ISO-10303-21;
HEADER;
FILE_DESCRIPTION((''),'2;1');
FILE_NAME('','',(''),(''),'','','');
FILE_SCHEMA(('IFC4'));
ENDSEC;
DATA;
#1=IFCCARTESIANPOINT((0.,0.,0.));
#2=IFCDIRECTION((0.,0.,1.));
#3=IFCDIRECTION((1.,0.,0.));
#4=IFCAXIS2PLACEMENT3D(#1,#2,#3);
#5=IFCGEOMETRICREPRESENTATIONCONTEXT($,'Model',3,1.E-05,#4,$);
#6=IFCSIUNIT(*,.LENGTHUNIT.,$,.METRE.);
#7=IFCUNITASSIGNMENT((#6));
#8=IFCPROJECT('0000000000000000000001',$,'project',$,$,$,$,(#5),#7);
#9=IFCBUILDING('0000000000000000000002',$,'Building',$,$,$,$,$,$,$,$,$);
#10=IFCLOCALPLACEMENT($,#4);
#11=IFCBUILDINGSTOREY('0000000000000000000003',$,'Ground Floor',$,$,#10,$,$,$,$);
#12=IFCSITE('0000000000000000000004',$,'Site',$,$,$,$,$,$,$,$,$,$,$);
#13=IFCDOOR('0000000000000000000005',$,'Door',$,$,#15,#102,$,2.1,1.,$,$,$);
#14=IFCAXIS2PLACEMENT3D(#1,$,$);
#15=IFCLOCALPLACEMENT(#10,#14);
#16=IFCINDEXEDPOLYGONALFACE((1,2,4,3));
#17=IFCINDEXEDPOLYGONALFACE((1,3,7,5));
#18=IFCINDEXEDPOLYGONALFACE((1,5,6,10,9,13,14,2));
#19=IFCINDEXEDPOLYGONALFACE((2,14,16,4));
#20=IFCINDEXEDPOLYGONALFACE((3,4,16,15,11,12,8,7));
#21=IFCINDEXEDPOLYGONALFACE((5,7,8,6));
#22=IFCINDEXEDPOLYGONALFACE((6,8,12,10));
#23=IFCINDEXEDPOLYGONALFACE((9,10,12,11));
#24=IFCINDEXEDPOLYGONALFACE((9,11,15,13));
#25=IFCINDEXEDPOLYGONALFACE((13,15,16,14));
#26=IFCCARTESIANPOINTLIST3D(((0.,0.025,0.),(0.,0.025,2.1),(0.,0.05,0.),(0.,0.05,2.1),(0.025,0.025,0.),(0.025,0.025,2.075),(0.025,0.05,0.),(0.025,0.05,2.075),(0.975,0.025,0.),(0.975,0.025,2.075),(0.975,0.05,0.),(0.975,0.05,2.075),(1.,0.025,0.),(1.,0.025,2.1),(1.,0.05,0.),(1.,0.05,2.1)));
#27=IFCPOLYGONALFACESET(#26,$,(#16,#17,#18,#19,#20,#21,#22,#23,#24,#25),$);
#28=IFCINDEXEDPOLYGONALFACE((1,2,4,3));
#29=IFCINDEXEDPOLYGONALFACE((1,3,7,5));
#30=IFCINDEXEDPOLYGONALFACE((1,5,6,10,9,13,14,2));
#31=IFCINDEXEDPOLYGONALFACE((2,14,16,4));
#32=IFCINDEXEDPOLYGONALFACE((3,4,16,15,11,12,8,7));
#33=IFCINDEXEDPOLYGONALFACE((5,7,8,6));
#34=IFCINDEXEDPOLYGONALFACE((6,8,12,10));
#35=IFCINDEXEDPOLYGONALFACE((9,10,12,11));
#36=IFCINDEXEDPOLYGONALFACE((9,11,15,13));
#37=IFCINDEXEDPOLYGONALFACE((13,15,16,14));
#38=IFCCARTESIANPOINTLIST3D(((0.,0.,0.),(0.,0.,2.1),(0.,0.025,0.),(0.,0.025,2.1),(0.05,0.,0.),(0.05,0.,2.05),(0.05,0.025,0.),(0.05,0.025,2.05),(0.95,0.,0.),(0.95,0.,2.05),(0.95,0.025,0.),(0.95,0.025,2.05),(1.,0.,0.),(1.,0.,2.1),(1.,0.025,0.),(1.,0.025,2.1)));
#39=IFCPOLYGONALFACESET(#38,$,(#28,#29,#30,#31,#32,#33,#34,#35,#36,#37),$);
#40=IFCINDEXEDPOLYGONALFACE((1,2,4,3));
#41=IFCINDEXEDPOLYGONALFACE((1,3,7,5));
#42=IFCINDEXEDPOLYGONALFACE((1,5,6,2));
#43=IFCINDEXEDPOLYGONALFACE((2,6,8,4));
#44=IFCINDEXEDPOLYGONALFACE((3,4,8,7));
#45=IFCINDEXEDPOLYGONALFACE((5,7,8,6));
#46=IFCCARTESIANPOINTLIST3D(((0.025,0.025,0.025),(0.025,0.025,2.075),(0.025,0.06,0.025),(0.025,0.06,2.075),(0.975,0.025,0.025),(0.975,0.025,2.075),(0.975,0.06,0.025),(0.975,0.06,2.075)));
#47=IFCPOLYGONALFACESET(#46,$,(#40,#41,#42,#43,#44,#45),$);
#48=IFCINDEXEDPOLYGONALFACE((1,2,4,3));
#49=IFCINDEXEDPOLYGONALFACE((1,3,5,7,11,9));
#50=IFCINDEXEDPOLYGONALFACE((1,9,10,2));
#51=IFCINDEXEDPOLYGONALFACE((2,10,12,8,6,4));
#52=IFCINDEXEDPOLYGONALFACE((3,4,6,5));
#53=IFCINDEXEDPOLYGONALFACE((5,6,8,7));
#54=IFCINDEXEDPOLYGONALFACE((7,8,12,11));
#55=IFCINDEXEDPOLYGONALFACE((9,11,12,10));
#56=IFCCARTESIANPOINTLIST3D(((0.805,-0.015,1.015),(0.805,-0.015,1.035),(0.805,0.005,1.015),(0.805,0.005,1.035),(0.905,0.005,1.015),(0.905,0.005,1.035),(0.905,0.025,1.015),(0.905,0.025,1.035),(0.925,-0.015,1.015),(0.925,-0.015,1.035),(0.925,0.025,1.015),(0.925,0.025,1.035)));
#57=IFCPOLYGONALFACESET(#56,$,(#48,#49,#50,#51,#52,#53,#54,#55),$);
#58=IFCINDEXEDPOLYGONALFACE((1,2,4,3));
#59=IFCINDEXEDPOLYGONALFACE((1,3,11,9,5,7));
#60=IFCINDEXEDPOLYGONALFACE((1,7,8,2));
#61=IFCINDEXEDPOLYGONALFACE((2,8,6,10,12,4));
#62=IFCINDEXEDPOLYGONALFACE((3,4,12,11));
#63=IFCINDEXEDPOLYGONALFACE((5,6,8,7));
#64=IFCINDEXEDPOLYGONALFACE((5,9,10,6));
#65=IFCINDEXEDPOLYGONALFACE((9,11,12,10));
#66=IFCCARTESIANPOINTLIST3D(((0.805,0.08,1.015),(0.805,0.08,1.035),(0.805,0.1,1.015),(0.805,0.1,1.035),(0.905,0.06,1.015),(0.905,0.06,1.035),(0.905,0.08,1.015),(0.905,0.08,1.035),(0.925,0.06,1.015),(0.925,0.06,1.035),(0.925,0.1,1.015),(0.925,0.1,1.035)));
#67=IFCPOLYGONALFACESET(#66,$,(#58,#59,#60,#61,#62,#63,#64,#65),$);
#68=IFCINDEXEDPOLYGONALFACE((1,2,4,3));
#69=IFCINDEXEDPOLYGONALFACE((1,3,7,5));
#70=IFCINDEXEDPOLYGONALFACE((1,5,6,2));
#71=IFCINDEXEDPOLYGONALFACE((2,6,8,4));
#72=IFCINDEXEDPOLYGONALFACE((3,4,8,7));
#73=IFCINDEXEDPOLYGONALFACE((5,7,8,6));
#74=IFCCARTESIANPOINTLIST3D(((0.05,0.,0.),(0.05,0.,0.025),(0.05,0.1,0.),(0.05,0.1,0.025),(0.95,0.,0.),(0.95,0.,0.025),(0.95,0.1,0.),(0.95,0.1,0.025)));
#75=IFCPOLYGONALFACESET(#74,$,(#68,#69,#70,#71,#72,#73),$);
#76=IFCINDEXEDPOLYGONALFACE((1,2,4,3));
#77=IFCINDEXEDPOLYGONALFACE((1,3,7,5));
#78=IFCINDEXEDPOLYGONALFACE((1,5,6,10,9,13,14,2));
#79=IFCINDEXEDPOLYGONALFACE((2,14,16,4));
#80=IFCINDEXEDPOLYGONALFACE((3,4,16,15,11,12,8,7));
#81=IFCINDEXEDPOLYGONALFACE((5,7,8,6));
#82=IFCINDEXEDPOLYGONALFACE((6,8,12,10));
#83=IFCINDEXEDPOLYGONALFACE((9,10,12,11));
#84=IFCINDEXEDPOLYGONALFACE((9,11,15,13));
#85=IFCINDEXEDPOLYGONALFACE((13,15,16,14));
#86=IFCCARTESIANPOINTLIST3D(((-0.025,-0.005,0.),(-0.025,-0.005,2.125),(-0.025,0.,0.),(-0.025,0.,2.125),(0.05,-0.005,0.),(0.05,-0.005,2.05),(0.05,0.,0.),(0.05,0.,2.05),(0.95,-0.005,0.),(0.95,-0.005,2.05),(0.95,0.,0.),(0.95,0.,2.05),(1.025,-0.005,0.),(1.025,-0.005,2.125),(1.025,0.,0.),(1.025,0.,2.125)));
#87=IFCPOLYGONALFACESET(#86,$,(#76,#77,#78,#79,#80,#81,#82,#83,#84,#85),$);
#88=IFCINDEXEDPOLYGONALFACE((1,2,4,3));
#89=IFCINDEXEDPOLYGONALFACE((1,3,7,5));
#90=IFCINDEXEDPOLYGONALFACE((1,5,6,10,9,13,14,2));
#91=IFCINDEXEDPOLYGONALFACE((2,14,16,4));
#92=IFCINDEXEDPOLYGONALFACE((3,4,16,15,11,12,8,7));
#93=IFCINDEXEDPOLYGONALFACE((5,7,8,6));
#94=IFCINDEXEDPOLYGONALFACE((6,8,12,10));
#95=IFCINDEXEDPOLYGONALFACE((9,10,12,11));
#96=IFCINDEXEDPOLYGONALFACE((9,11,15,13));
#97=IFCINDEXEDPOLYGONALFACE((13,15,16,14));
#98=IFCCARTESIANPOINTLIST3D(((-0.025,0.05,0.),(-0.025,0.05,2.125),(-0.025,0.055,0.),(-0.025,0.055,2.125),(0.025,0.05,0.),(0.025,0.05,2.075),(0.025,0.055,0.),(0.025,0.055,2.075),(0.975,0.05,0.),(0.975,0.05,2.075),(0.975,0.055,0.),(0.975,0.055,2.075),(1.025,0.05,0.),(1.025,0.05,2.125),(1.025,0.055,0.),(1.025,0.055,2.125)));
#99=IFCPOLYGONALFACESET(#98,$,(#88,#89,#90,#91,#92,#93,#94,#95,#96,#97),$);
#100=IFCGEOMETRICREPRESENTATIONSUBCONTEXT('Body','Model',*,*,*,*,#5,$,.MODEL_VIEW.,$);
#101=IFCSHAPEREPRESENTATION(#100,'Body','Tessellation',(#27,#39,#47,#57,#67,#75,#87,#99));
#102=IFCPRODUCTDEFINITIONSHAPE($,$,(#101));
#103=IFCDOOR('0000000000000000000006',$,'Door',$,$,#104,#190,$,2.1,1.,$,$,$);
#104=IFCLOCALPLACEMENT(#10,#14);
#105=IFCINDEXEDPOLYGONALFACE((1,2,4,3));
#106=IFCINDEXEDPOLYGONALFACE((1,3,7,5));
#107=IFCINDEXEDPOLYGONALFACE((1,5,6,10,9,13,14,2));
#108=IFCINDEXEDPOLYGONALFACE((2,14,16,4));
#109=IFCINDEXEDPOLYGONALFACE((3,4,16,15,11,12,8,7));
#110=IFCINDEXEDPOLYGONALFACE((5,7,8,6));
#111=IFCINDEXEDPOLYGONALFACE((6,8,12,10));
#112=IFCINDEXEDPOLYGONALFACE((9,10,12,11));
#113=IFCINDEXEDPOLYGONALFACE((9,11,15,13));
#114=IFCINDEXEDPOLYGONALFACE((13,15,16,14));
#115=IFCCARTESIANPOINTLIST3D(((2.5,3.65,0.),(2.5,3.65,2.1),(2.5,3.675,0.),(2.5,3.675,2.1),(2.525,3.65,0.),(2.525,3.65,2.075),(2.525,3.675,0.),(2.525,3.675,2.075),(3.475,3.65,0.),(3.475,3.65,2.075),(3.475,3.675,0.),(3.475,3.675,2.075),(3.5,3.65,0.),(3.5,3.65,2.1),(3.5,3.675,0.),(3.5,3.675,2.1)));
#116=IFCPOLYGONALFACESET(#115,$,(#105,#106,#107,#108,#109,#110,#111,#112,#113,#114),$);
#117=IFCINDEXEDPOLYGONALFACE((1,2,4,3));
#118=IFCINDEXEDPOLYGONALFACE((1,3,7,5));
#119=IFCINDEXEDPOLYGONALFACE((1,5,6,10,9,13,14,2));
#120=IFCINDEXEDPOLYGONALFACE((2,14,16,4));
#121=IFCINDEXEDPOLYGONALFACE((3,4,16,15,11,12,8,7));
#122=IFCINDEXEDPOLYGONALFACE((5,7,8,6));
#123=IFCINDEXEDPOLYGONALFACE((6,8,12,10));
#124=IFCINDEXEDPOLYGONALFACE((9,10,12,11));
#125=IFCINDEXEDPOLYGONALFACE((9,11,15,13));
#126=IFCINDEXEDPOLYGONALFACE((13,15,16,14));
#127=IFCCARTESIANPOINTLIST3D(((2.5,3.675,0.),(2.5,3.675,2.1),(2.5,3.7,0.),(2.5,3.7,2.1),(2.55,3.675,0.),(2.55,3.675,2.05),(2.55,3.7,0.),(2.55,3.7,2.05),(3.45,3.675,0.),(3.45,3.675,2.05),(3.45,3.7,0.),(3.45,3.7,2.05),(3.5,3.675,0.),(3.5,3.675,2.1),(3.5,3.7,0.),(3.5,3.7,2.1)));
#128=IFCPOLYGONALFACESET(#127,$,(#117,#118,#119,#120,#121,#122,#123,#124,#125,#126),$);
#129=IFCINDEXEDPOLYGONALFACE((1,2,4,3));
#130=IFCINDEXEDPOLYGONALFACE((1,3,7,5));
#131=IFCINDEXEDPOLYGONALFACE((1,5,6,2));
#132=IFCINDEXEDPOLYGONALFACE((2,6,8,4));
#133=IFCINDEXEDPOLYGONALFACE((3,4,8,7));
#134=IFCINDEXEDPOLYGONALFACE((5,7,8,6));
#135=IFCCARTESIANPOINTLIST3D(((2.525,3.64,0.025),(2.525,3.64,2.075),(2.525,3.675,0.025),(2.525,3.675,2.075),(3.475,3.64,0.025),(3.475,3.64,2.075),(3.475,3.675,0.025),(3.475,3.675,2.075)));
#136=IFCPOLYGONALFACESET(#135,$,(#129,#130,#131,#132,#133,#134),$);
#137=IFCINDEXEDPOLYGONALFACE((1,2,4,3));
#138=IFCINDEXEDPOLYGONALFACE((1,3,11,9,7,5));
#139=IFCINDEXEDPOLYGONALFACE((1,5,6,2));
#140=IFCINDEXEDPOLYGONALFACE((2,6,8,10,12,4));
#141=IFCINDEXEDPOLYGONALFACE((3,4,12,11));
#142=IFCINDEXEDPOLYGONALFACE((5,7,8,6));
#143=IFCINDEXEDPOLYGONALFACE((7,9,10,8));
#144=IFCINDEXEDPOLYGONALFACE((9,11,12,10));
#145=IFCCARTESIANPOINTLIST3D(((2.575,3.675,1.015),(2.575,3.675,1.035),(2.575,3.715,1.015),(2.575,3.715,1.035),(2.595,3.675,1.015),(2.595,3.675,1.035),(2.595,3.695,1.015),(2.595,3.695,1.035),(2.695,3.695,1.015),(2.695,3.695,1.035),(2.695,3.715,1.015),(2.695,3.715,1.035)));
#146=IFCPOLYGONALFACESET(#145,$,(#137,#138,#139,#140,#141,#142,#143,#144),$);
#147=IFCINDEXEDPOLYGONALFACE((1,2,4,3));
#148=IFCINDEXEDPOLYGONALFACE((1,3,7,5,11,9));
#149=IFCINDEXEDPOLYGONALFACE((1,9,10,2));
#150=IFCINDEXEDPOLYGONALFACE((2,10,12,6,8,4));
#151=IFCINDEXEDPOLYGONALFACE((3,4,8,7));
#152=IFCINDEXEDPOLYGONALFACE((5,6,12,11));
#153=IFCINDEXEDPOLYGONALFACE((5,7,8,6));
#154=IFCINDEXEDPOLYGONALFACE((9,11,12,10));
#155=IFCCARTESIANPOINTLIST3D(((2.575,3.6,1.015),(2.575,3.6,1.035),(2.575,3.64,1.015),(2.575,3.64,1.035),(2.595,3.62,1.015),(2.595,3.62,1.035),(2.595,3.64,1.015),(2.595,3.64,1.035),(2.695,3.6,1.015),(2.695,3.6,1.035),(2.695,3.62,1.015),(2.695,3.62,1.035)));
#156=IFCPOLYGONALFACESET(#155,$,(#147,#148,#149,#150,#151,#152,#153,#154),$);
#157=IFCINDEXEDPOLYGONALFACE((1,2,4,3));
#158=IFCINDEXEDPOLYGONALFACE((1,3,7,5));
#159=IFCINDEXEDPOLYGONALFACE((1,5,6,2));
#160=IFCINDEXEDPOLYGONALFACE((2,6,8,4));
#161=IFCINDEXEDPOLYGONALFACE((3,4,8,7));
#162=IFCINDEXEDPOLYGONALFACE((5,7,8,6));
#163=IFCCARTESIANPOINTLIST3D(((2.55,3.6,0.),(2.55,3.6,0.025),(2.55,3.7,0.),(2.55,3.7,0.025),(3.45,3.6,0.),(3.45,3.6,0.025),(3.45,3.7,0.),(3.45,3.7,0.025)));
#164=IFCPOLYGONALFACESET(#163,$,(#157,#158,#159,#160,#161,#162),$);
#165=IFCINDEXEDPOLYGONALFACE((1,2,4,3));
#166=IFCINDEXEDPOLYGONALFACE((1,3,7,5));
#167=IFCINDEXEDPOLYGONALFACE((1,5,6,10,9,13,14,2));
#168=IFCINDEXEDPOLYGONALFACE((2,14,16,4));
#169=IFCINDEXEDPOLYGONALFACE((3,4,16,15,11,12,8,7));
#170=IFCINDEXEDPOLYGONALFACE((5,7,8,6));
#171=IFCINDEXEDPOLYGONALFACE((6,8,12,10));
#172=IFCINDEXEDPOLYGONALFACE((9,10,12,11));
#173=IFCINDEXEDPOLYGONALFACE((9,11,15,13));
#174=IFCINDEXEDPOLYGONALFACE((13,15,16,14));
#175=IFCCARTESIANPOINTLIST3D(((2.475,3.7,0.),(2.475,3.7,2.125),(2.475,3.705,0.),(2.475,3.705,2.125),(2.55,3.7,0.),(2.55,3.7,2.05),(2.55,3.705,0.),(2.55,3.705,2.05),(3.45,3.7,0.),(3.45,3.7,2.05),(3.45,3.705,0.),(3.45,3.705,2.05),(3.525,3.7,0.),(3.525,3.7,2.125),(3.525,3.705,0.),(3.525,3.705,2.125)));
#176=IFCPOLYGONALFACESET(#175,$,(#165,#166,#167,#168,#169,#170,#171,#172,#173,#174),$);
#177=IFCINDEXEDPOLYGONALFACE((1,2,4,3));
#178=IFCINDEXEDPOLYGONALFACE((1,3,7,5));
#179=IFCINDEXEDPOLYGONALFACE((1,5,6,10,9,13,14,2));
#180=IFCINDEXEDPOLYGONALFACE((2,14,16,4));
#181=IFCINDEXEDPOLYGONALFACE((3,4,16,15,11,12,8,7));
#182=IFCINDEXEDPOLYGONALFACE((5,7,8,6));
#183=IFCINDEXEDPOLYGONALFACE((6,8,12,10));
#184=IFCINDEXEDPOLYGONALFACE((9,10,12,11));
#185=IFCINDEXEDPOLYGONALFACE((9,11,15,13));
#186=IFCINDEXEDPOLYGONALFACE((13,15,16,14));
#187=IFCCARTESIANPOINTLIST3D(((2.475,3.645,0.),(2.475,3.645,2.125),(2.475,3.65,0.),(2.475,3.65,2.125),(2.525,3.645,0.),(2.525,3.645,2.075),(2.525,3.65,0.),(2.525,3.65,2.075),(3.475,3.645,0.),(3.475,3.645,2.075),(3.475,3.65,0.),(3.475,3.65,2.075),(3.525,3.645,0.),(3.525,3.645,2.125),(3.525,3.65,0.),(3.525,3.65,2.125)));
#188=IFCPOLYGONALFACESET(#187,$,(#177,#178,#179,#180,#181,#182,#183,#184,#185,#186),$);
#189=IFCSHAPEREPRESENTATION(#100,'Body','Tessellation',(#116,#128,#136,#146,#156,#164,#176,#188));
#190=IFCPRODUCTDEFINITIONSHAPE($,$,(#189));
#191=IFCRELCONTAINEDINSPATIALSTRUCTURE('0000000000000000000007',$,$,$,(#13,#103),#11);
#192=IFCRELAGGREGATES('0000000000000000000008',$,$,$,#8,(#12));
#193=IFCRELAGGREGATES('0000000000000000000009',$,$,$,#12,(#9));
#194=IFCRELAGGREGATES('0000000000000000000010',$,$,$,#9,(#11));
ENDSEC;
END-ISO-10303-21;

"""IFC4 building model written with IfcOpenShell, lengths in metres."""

from ifc_helpers import new_model, si_unit, frame, origin_with_axes, place, context, subcontext, project, spatial, line, indexed_curve, outline, extrude, element, save


model = new_model("IFC4")

# Units and contexts
model_context = context("Model", 3, precision=1e-05, world=origin_with_axes())
body_context = subcontext(model_context, "Body", "Model", "MODEL_VIEW")
ifc_project = project(units=[si_unit("LENGTHUNIT", "METRE")], contexts=[model_context])

# Site, building, storey
site = spatial("IfcSite", under=ifc_project, Name="Site")
building = spatial("IfcBuilding", under=site, Name="Building")
storey_placement = place(None, origin_with_axes())
storey = spatial("IfcBuildingStorey", under=building, at=storey_placement, Name="Ground Floor")

# Doors
door_1_placement = place(storey_placement, origin_with_axes())
element("IfcDoor", 1, at=door_1_placement, inside=storey, Name="Door", OverallHeight=2.1, OverallWidth=1.0, context=body_context, shape_type="SweptSolid", body=[
    extrude(outline(indexed_curve([(0.0, 0.0), (0.0, 2.1), (1.0, 2.1), (1.0, 0.0), (0.975, 0.0), (0.975, 2.075), (0.025, 2.075), (0.025, 0.0)], segments=[line(1, 2, 3, 4, 5, 6, 7, 8, 1)])), frame((0.0, 0.025, 0.0), z_axis=(0.0, -1.0, 0.0), x_axis=(1.0, 0.0, 0.0)), (0.0, 0.0, -1.0), 0.025),
    extrude(outline(indexed_curve([(0.0, 0.0), (0.0, 2.1), (1.0, 2.1), (1.0, 0.0), (0.95, 0.0), (0.95, 2.05), (0.05, 2.05), (0.05, 0.0)], segments=[line(1, 2, 3, 4, 5, 6, 7, 8, 1)])), frame((0.0, 0.0, 0.0), z_axis=(0.0, -1.0, 0.0), x_axis=(1.0, 0.0, 0.0)), (0.0, 0.0, -1.0), 0.025),
    extrude(outline(indexed_curve([(0.0, 0.0), (0.95, 0.0), (0.95, 0.035), (0.0, 0.035)], segments=[line(1, 2, 3, 4, 1)])), frame((0.025, 0.025, 0.025), z_axis=(0.0, 0.0, 1.0), x_axis=(1.0, 0.0, 0.0)), (0.0, 0.0, 1.0), 2.05),
    extrude(outline(indexed_curve([(0.0, 0.0), (0.0, -0.04), (-0.12, -0.04), (-0.12, -0.02), (-0.02, -0.02), (-0.02, 0.0)], segments=[line(1, 2, 3, 4, 5, 6, 1)])), frame((0.925, 0.025, 1.015), z_axis=(0.0, 0.0, 1.0), x_axis=(1.0, 0.0, 0.0)), (0.0, 0.0, 1.0), 0.02),
    extrude(outline(indexed_curve([(0.0, 0.0), (0.0, 0.04), (-0.12, 0.04), (-0.12, 0.02), (-0.02, 0.02), (-0.02, 0.0)], segments=[line(1, 2, 3, 4, 5, 6, 1)])), frame((0.925, 0.06, 1.015), z_axis=(0.0, 0.0, 1.0), x_axis=(1.0, 0.0, 0.0)), (0.0, 0.0, 1.0), 0.02),
    extrude(outline(indexed_curve([(0.0, 0.0), (0.9, 0.0), (0.9, 0.1), (0.0, 0.1)], segments=[line(1, 2, 3, 4, 1)])), frame((0.05, 0.0, 0.0), z_axis=(0.0, 0.0, 1.0), x_axis=(1.0, 0.0, 0.0)), (0.0, 0.0, 1.0), 0.025),
    extrude(outline(indexed_curve([(0.0, 0.0), (0.0, 2.125), (1.05, 2.125), (1.05, 0.0), (0.975, 0.0), (0.975, 2.05), (0.075, 2.05), (0.075, 0.0)], segments=[line(1, 2, 3, 4, 5, 6, 7, 8, 1)])), frame((-0.025, -0.005, 0.0), z_axis=(0.0, -1.0, 0.0), x_axis=(1.0, 0.0, 0.0)), (0.0, 0.0, -1.0), 0.005),
    extrude(outline(indexed_curve([(0.0, 0.0), (0.0, 2.125), (1.05, 2.125), (1.05, 0.0), (1.0, 0.0), (1.0, 2.075), (0.05, 2.075), (0.05, 0.0)], segments=[line(1, 2, 3, 4, 5, 6, 7, 8, 1)])), frame((-0.025, 0.05, 0.0), z_axis=(0.0, -1.0, 0.0), x_axis=(1.0, 0.0, 0.0)), (0.0, 0.0, -1.0), 0.005),
])
door_2_placement = place(storey_placement, frame((3.5, 3.7, 0.0), z_axis=(0.0, 0.0, 1.0), x_axis=(-1.0, 0.0, 0.0)))
element("IfcDoor", 2, at=door_2_placement, inside=storey, Name="Door", OverallHeight=2.1, OverallWidth=1.0, context=body_context, shape_type="SweptSolid", body=[
    extrude(outline(indexed_curve([(0.0, 0.0), (0.0, 2.1), (1.0, 2.1), (1.0, 0.0), (0.975, 0.0), (0.975, 2.075), (0.025, 2.075), (0.025, 0.0)], segments=[line(1, 2, 3, 4, 5, 6, 7, 8, 1)])), frame((0.0, 0.025, 0.0), z_axis=(0.0, -1.0, 0.0), x_axis=(1.0, 0.0, 0.0)), (0.0, 0.0, -1.0), 0.025),
    extrude(outline(indexed_curve([(0.0, 0.0), (0.0, 2.1), (1.0, 2.1), (1.0, 0.0), (0.95, 0.0), (0.95, 2.05), (0.05, 2.05), (0.05, 0.0)], segments=[line(1, 2, 3, 4, 5, 6, 7, 8, 1)])), frame((0.0, 0.0, 0.0), z_axis=(0.0, -1.0, 0.0), x_axis=(1.0, 0.0, 0.0)), (0.0, 0.0, -1.0), 0.025),
    extrude(outline(indexed_curve([(0.0, 0.0), (0.95, 0.0), (0.95, 0.035), (0.0, 0.035)], segments=[line(1, 2, 3, 4, 1)])), frame((0.025, 0.025, 0.025), z_axis=(0.0, 0.0, 1.0), x_axis=(1.0, 0.0, 0.0)), (0.0, 0.0, 1.0), 2.05),
    extrude(outline(indexed_curve([(0.0, 0.0), (0.0, -0.04), (-0.12, -0.04), (-0.12, -0.02), (-0.02, -0.02), (-0.02, 0.0)], segments=[line(1, 2, 3, 4, 5, 6, 1)])), frame((0.925, 0.025, 1.015), z_axis=(0.0, 0.0, 1.0), x_axis=(1.0, 0.0, 0.0)), (0.0, 0.0, 1.0), 0.02),
    extrude(outline(indexed_curve([(0.0, 0.0), (0.0, 0.04), (-0.12, 0.04), (-0.12, 0.02), (-0.02, 0.02), (-0.02, 0.0)], segments=[line(1, 2, 3, 4, 5, 6, 1)])), frame((0.925, 0.06, 1.015), z_axis=(0.0, 0.0, 1.0), x_axis=(1.0, 0.0, 0.0)), (0.0, 0.0, 1.0), 0.02),
    extrude(outline(indexed_curve([(0.0, 0.0), (0.9, 0.0), (0.9, 0.1), (0.0, 0.1)], segments=[line(1, 2, 3, 4, 1)])), frame((0.05, 0.0, 0.0), z_axis=(0.0, 0.0, 1.0), x_axis=(1.0, 0.0, 0.0)), (0.0, 0.0, 1.0), 0.025),
    extrude(outline(indexed_curve([(0.0, 0.0), (0.0, 2.125), (1.05, 2.125), (1.05, 0.0), (0.975, 0.0), (0.975, 2.05), (0.075, 2.05), (0.075, 0.0)], segments=[line(1, 2, 3, 4, 5, 6, 7, 8, 1)])), frame((-0.025, -0.005, 0.0), z_axis=(0.0, -1.0, 0.0), x_axis=(1.0, 0.0, 0.0)), (0.0, 0.0, -1.0), 0.005),
    extrude(outline(indexed_curve([(0.0, 0.0), (0.0, 2.125), (1.05, 2.125), (1.05, 0.0), (1.0, 0.0), (1.0, 2.075), (0.05, 2.075), (0.05, 0.0)], segments=[line(1, 2, 3, 4, 5, 6, 7, 8, 1)])), frame((-0.025, 0.05, 0.0), z_axis=(0.0, -1.0, 0.0), x_axis=(1.0, 0.0, 0.0)), (0.0, 0.0, -1.0), 0.005),
])

save(model, "model.ifc")
